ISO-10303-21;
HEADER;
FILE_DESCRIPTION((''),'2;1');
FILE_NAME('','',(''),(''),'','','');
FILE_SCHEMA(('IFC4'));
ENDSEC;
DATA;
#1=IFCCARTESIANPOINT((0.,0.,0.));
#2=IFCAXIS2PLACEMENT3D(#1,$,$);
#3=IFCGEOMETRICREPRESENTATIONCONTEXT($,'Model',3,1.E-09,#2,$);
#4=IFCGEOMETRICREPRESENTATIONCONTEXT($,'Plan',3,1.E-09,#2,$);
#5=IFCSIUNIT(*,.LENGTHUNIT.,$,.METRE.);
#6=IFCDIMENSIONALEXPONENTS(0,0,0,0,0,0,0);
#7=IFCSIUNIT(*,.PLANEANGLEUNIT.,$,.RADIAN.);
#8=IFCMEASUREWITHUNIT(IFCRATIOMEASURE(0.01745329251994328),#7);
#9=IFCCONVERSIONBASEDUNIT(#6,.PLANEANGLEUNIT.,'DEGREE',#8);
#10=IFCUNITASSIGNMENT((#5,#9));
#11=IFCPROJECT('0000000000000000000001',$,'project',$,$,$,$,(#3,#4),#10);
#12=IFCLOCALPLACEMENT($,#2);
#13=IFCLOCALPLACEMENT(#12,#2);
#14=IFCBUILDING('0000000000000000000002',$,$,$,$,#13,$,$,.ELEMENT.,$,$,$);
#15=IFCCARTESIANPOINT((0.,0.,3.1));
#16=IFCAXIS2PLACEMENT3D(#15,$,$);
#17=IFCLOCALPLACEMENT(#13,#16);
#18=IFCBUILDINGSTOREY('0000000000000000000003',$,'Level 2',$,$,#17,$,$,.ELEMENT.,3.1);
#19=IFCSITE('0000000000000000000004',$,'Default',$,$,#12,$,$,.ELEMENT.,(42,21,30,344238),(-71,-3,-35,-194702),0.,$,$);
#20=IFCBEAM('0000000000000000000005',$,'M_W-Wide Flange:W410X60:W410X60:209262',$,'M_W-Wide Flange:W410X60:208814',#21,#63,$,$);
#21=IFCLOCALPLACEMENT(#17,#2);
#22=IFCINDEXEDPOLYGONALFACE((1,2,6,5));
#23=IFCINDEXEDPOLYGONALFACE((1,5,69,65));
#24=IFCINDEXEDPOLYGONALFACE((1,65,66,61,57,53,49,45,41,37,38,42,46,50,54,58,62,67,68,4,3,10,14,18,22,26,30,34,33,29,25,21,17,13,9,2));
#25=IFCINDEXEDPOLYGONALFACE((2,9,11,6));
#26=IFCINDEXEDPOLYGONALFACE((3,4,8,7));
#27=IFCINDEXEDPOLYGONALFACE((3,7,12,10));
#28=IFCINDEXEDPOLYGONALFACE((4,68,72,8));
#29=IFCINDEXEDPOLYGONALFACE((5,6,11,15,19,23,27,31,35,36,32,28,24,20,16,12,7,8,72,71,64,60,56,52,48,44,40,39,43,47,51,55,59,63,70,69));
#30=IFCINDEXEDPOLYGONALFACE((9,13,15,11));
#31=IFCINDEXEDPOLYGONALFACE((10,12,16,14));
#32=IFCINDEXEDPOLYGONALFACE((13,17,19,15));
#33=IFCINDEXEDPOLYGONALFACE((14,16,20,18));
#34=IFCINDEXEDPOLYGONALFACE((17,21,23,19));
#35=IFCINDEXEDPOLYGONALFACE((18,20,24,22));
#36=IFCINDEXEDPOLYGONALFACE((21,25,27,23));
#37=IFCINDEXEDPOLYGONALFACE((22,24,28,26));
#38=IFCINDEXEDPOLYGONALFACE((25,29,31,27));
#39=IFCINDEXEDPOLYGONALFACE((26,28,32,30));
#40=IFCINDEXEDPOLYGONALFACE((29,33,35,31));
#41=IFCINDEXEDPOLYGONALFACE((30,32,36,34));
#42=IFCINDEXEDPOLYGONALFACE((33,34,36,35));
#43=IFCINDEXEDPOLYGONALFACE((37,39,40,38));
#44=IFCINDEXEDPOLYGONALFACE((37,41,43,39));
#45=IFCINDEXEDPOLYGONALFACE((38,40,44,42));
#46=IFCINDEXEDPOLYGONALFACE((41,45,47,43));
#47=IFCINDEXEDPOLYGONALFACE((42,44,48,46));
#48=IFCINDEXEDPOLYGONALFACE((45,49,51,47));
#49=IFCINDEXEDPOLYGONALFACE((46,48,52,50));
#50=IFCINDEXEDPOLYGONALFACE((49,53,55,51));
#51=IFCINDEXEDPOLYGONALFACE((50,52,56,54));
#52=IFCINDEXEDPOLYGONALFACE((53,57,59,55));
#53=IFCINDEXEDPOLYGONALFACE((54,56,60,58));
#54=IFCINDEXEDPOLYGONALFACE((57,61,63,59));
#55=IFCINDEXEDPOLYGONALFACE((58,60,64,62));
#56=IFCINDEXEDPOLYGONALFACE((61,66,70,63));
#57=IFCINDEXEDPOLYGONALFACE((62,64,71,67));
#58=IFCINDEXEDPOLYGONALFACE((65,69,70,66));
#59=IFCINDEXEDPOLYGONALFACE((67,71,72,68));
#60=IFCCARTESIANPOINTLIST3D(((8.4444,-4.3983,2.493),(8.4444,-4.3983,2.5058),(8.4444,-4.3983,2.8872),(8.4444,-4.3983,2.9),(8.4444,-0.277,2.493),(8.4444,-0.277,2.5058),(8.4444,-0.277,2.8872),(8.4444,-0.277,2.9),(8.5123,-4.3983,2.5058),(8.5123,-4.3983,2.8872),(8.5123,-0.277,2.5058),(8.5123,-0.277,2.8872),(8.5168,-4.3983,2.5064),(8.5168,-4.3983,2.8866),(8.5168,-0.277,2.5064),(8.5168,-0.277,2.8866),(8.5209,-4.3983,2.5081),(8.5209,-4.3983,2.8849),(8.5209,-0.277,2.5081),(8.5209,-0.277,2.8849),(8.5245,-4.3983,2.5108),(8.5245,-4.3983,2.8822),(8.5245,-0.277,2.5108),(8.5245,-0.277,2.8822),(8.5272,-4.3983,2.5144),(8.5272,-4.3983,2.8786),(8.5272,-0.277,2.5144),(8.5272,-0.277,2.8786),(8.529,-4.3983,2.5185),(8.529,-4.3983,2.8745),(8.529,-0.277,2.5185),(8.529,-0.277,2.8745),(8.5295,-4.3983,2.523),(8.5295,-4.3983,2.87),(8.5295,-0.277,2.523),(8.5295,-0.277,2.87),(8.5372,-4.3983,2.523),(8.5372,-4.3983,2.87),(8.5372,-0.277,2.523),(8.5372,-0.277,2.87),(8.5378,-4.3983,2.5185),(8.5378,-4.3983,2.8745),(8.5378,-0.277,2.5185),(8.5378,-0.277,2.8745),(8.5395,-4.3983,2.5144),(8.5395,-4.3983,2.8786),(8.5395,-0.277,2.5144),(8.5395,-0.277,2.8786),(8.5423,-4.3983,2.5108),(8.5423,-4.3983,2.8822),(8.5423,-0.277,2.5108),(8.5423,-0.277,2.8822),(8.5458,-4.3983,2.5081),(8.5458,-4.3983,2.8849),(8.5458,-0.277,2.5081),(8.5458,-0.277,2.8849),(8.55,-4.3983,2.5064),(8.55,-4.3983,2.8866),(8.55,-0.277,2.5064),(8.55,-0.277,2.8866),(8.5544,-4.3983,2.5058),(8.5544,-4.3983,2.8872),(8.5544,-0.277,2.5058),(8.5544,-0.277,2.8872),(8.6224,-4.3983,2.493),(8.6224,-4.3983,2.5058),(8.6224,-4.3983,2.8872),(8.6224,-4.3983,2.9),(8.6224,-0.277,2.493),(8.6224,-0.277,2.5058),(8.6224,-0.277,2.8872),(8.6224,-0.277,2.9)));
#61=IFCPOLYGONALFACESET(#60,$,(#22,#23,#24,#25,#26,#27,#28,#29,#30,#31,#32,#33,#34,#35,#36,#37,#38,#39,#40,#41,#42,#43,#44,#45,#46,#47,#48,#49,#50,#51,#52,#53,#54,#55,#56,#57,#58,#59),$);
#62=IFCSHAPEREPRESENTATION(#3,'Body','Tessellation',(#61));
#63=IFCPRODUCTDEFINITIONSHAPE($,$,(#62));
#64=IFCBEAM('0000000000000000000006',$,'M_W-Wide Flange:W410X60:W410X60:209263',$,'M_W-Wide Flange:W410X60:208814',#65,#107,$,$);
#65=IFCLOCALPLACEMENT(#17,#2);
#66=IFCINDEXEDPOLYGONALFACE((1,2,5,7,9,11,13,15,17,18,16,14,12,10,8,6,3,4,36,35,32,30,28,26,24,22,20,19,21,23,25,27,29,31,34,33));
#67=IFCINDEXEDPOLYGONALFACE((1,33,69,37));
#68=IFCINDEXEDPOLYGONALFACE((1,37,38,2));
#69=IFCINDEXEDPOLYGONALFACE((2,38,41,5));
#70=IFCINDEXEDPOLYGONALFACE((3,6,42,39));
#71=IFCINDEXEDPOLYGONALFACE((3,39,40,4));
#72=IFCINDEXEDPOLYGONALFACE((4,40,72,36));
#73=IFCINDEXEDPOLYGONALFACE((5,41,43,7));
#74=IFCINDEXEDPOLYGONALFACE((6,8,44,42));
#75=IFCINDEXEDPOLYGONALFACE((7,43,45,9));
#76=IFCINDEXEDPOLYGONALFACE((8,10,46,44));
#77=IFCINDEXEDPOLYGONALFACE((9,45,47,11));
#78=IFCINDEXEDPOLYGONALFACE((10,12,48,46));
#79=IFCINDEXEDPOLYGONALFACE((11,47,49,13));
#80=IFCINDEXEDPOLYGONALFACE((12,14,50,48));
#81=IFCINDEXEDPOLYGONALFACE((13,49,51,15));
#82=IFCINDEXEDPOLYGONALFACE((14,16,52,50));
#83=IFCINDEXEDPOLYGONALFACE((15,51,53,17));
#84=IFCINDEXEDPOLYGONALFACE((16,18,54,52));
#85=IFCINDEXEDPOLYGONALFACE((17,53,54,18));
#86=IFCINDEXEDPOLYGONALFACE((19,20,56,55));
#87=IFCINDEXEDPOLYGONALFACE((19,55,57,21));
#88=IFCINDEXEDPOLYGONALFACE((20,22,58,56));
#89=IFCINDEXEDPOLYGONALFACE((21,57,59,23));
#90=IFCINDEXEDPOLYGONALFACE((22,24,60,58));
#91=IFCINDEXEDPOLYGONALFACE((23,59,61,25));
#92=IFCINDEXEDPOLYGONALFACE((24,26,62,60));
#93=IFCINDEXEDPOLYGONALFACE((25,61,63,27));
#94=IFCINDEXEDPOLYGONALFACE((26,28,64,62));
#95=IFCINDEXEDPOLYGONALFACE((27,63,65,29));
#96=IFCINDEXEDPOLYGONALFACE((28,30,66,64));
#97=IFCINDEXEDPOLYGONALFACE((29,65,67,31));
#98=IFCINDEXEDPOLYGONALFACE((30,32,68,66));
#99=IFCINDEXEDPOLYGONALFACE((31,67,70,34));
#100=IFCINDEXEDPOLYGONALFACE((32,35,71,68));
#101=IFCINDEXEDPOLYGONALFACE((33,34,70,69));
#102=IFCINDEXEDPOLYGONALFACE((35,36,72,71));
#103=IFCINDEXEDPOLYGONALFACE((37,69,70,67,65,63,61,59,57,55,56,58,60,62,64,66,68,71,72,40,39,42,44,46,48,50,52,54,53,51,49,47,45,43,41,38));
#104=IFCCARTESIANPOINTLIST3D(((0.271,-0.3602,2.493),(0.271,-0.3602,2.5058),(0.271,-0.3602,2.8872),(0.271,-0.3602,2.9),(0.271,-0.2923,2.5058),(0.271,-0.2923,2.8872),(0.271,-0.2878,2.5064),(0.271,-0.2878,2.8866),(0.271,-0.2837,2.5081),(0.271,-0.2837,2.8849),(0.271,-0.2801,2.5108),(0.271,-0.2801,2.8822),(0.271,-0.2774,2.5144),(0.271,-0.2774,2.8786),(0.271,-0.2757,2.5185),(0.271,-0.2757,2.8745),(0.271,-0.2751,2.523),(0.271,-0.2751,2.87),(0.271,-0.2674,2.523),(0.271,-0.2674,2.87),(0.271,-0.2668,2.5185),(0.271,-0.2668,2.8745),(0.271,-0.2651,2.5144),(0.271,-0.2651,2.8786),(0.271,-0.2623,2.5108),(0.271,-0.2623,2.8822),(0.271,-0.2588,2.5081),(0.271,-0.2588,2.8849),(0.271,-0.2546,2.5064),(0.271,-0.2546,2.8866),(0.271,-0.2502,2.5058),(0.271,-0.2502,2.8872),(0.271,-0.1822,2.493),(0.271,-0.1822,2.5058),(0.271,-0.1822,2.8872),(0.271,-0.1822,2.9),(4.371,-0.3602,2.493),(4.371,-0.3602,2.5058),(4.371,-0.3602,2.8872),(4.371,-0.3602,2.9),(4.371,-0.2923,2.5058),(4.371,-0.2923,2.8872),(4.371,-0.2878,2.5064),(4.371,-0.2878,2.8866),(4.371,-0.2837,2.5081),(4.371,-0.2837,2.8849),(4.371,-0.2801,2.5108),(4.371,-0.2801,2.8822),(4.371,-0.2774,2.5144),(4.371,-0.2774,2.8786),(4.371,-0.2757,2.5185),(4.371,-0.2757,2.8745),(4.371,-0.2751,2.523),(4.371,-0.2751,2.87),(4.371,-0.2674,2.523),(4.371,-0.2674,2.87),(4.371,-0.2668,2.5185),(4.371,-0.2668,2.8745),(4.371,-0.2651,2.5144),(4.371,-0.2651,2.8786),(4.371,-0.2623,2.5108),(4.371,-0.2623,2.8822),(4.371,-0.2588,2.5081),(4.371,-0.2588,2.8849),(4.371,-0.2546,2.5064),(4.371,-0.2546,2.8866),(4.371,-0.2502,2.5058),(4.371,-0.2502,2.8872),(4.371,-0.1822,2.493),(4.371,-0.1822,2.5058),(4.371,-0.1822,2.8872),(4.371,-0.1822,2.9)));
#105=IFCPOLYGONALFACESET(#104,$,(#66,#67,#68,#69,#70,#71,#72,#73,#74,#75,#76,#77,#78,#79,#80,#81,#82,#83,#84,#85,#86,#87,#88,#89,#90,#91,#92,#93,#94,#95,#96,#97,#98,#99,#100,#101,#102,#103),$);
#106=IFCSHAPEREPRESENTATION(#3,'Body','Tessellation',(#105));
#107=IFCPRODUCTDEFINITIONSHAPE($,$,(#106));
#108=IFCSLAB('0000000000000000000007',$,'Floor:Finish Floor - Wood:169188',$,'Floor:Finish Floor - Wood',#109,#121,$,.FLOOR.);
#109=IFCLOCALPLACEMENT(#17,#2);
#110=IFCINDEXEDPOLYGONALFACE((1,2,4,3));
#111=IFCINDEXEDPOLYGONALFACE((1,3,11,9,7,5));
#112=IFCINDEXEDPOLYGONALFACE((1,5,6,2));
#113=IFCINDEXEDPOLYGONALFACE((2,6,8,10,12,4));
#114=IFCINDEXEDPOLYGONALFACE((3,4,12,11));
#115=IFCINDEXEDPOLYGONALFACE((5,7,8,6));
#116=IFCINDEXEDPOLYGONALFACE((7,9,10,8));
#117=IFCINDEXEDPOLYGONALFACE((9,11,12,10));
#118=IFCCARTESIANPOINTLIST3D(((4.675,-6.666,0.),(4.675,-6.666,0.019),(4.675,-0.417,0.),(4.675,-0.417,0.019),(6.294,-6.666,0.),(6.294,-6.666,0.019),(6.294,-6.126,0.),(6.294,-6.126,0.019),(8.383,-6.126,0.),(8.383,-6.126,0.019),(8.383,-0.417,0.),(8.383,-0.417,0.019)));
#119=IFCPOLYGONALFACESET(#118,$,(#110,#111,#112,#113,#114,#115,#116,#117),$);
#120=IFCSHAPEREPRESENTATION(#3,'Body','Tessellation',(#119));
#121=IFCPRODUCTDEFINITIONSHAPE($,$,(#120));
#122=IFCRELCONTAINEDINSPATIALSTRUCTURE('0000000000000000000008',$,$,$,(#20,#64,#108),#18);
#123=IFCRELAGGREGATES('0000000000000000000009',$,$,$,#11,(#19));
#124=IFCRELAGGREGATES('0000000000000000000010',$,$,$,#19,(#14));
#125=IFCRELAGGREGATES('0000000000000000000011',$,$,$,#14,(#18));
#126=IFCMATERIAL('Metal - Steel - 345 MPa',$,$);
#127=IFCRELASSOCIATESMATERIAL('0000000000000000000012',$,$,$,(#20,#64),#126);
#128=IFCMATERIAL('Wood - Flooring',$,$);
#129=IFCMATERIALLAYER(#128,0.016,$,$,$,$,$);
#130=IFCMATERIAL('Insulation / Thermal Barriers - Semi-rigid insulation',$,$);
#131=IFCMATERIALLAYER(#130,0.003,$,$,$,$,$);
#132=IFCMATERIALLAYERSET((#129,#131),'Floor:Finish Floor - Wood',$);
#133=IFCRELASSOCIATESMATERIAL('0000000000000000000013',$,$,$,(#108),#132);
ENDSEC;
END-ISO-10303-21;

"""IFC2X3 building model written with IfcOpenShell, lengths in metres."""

from ifc_helpers import new_model, entity, si_unit, converted_unit, frame, frame_2d, origin, place, context, project, spatial, polyline, circle_curve, parameter, trimmed, segment, composite_curve, outline, extrude, material, layer, layer_set, layer_usage, element, save


model = new_model("IFC2X3")

# Units and contexts
model_context = context("Model", 3, precision=1e-09, world=origin())
plan_context = context("Plan", 3, precision=1e-09, world=origin())
ifc_project = project(units=[si_unit("LENGTHUNIT", "METRE"), converted_unit("PLANEANGLEUNIT", "DEGREE", entity("IfcRatioMeasure", 0.01745329251994328), si_unit("PLANEANGLEUNIT", "RADIAN"), dimensions=[0, 0, 0, 0, 0, 0, 0])], contexts=[model_context, plan_context])

# Site, building, storey
site_placement = place(None, origin())
site = spatial("IfcSite", under=ifc_project, at=site_placement, Name="Default", CompositionType="ELEMENT", RefLatitude=(42, 21, 30, 344238), RefLongitude=(-71, -3, -35, -194702), RefElevation=0.0)
building_placement = place(site_placement, origin())
building = spatial("IfcBuilding", under=site, at=building_placement, CompositionType="ELEMENT")
storey_placement = place(building_placement, frame((0.0, 0.0, 3.1)))
storey = spatial("IfcBuildingStorey", under=building, at=storey_placement, Name="Level 2", CompositionType="ELEMENT", Elevation=3.1)

# Beams
ifc_material_1 = material(Name="Metal - Steel - 345 MPa")
beam_1_placement = place(storey_placement, frame((8.5334, -4.3983, 2.9)))
element("IfcBeam", 1, at=beam_1_placement, inside=storey, material=ifc_material_1, Name="M_W-Wide Flange:W410X60:W410X60:209262", ObjectType="M_W-Wide Flange:W410X60:208814", context=model_context, shape_type="SweptSolid", body=[
    extrude(outline(composite_curve([segment(polyline([(-0.089, -0.1907), (-0.089, -0.2035)]), True, "CONTINUOUS"), segment(polyline([(-0.089, -0.2035), (0.089, -0.2035)]), True, "CONTINUOUS"), segment(polyline([(0.089, -0.2035), (0.089, -0.1907)]), True, "CONTINUOUS"), segment(polyline([(0.089, -0.1907), (0.021, -0.1907)]), True, "CONTINUOUS"), segment(trimmed(circle_curve(frame_2d((0.021, -0.1735), x_axis=(0.0, -1.0)), 0.0172), [parameter(270.0)], [parameter(360.0)], True, "PARAMETER"), False, "CONTINUOUS"), segment(polyline([(0.0038, -0.1735), (0.0038, 0.1735)]), True, "CONTINUOUS"), segment(trimmed(circle_curve(frame_2d((0.021, 0.1735), x_axis=(-1.0, 0.0)), 0.0172), [parameter(270.0)], [parameter(360.0)], True, "PARAMETER"), False, "CONTINUOUS"), segment(polyline([(0.021, 0.1907), (0.089, 0.1907)]), True, "CONTINUOUS"), segment(polyline([(0.089, 0.1907), (0.089, 0.2035)]), True, "CONTINUOUS"), segment(polyline([(0.089, 0.2035), (-0.089, 0.2035)]), True, "CONTINUOUS"), segment(polyline([(-0.089, 0.2035), (-0.089, 0.1907)]), True, "CONTINUOUS"), segment(polyline([(-0.089, 0.1907), (-0.0211, 0.1907)]), True, "CONTINUOUS"), segment(trimmed(circle_curve(frame_2d((-0.0211, 0.1735), x_axis=(0.0, 1.0)), 0.0172), [parameter(270.0)], [parameter(0.0)], True, "PARAMETER"), False, "CONTINUOUS"), segment(polyline([(-0.0039, 0.1735), (-0.0039, -0.1735)]), True, "CONTINUOUS"), segment(trimmed(circle_curve(frame_2d((-0.0211, -0.1735), x_axis=(1.0, 0.0)), 0.0172), [parameter(270.0)], [parameter(0.0)], True, "PARAMETER"), False, "CONTINUOUS"), segment(polyline([(-0.0211, -0.1907), (-0.089, -0.1907)]), True, "CONTINUOUS")], self_intersect=False)), frame((0.0, 0.0, -0.2035), z_axis=(0.0, -1.0, 0.0), x_axis=(1.0, 0.0, 0.0)), (0.0, 0.0, -1.0), 4.1213),
])
beam_2_placement = place(storey_placement, frame((4.371, -0.2712, 2.9), z_axis=(0.0, 0.0, 1.0), x_axis=(0.0, 1.0, 0.0)))
element("IfcBeam", 2, at=beam_2_placement, inside=storey, material=ifc_material_1, Name="M_W-Wide Flange:W410X60:W410X60:209263", ObjectType="M_W-Wide Flange:W410X60:208814", context=model_context, shape_type="SweptSolid", body=[
    extrude(outline(composite_curve([segment(polyline([(0.1907, -0.089), (0.2035, -0.089)]), True, "CONTINUOUS"), segment(polyline([(0.2035, -0.089), (0.2035, 0.089)]), True, "CONTINUOUS"), segment(polyline([(0.2035, 0.089), (0.1907, 0.089)]), True, "CONTINUOUS"), segment(polyline([(0.1907, 0.089), (0.1907, 0.0211)]), True, "CONTINUOUS"), segment(trimmed(circle_curve(frame_2d((0.1735, 0.0211), x_axis=(1.0, 0.0)), 0.0172), [parameter(270.0)], [parameter(360.0)], True, "PARAMETER"), False, "CONTINUOUS"), segment(polyline([(0.1735, 0.0039), (-0.1735, 0.0039)]), True, "CONTINUOUS"), segment(trimmed(circle_curve(frame_2d((-0.1735, 0.0211), x_axis=(0.0, -1.0)), 0.0172), [parameter(270.0)], [parameter(360.0)], True, "PARAMETER"), False, "CONTINUOUS"), segment(polyline([(-0.1907, 0.0211), (-0.1907, 0.089)]), True, "CONTINUOUS"), segment(polyline([(-0.1907, 0.089), (-0.2035, 0.089)]), True, "CONTINUOUS"), segment(polyline([(-0.2035, 0.089), (-0.2035, -0.089)]), True, "CONTINUOUS"), segment(polyline([(-0.2035, -0.089), (-0.1907, -0.089)]), True, "CONTINUOUS"), segment(polyline([(-0.1907, -0.089), (-0.1907, -0.0211)]), True, "CONTINUOUS"), segment(trimmed(circle_curve(frame_2d((-0.1735, -0.0211), x_axis=(-1.0, 0.0)), 0.0172), [parameter(270.0)], [parameter(0.0)], True, "PARAMETER"), False, "CONTINUOUS"), segment(polyline([(-0.1735, -0.0039), (0.1735, -0.0039)]), True, "CONTINUOUS"), segment(trimmed(circle_curve(frame_2d((0.1735, -0.0211), x_axis=(0.0, 1.0)), 0.0172), [parameter(270.0)], [parameter(0.0)], True, "PARAMETER"), False, "CONTINUOUS"), segment(polyline([(0.1907, -0.0211), (0.1907, -0.089)]), True, "CONTINUOUS")], self_intersect=False)), frame((0.0, 4.1, -0.2035), z_axis=(0.0, -1.0, 0.0), x_axis=(0.0, 0.0, -1.0)), (0.0, 0.0, 1.0), 4.1),
])

# Slab
ifc_material_2 = material(Name="Wood - Flooring")
ifc_layer_1 = layer(ifc_material_2, 0.016)
ifc_material_3 = material(Name="Insulation / Thermal Barriers - Semi-rigid insulation")
ifc_layer_2 = layer(ifc_material_3, 0.003)
ifc_layer_set_1 = layer_set([ifc_layer_1, ifc_layer_2], Name="Floor:Finish Floor - Wood")
ifc_layer_usage_1 = layer_usage(ifc_layer_set_1, "AXIS3", "POSITIVE", 0.0)
slab_placement = place(storey_placement, frame((4.675, -6.666, 0.0)))
element("IfcSlab", 3, at=slab_placement, inside=storey, material=ifc_layer_usage_1, Name="Floor:Finish Floor - Wood:169188", ObjectType="Floor:Finish Floor - Wood", PredefinedType="FLOOR", context=model_context, shape_type="SweptSolid", body=[
    extrude(outline(polyline([(-1.854, 3.1245), (-1.854, -2.5845), (0.235, -2.5845), (0.235, -3.1245), (1.854, -3.1245), (1.854, 3.1245), (-1.854, 3.1245)])), frame((1.854, 3.1245, 0.019), z_axis=(0.0, 0.0, -1.0), x_axis=(-1.0, 0.0, 0.0)), (0.0, 0.0, 1.0), 0.019),
])

save(model, "model.ifc")
